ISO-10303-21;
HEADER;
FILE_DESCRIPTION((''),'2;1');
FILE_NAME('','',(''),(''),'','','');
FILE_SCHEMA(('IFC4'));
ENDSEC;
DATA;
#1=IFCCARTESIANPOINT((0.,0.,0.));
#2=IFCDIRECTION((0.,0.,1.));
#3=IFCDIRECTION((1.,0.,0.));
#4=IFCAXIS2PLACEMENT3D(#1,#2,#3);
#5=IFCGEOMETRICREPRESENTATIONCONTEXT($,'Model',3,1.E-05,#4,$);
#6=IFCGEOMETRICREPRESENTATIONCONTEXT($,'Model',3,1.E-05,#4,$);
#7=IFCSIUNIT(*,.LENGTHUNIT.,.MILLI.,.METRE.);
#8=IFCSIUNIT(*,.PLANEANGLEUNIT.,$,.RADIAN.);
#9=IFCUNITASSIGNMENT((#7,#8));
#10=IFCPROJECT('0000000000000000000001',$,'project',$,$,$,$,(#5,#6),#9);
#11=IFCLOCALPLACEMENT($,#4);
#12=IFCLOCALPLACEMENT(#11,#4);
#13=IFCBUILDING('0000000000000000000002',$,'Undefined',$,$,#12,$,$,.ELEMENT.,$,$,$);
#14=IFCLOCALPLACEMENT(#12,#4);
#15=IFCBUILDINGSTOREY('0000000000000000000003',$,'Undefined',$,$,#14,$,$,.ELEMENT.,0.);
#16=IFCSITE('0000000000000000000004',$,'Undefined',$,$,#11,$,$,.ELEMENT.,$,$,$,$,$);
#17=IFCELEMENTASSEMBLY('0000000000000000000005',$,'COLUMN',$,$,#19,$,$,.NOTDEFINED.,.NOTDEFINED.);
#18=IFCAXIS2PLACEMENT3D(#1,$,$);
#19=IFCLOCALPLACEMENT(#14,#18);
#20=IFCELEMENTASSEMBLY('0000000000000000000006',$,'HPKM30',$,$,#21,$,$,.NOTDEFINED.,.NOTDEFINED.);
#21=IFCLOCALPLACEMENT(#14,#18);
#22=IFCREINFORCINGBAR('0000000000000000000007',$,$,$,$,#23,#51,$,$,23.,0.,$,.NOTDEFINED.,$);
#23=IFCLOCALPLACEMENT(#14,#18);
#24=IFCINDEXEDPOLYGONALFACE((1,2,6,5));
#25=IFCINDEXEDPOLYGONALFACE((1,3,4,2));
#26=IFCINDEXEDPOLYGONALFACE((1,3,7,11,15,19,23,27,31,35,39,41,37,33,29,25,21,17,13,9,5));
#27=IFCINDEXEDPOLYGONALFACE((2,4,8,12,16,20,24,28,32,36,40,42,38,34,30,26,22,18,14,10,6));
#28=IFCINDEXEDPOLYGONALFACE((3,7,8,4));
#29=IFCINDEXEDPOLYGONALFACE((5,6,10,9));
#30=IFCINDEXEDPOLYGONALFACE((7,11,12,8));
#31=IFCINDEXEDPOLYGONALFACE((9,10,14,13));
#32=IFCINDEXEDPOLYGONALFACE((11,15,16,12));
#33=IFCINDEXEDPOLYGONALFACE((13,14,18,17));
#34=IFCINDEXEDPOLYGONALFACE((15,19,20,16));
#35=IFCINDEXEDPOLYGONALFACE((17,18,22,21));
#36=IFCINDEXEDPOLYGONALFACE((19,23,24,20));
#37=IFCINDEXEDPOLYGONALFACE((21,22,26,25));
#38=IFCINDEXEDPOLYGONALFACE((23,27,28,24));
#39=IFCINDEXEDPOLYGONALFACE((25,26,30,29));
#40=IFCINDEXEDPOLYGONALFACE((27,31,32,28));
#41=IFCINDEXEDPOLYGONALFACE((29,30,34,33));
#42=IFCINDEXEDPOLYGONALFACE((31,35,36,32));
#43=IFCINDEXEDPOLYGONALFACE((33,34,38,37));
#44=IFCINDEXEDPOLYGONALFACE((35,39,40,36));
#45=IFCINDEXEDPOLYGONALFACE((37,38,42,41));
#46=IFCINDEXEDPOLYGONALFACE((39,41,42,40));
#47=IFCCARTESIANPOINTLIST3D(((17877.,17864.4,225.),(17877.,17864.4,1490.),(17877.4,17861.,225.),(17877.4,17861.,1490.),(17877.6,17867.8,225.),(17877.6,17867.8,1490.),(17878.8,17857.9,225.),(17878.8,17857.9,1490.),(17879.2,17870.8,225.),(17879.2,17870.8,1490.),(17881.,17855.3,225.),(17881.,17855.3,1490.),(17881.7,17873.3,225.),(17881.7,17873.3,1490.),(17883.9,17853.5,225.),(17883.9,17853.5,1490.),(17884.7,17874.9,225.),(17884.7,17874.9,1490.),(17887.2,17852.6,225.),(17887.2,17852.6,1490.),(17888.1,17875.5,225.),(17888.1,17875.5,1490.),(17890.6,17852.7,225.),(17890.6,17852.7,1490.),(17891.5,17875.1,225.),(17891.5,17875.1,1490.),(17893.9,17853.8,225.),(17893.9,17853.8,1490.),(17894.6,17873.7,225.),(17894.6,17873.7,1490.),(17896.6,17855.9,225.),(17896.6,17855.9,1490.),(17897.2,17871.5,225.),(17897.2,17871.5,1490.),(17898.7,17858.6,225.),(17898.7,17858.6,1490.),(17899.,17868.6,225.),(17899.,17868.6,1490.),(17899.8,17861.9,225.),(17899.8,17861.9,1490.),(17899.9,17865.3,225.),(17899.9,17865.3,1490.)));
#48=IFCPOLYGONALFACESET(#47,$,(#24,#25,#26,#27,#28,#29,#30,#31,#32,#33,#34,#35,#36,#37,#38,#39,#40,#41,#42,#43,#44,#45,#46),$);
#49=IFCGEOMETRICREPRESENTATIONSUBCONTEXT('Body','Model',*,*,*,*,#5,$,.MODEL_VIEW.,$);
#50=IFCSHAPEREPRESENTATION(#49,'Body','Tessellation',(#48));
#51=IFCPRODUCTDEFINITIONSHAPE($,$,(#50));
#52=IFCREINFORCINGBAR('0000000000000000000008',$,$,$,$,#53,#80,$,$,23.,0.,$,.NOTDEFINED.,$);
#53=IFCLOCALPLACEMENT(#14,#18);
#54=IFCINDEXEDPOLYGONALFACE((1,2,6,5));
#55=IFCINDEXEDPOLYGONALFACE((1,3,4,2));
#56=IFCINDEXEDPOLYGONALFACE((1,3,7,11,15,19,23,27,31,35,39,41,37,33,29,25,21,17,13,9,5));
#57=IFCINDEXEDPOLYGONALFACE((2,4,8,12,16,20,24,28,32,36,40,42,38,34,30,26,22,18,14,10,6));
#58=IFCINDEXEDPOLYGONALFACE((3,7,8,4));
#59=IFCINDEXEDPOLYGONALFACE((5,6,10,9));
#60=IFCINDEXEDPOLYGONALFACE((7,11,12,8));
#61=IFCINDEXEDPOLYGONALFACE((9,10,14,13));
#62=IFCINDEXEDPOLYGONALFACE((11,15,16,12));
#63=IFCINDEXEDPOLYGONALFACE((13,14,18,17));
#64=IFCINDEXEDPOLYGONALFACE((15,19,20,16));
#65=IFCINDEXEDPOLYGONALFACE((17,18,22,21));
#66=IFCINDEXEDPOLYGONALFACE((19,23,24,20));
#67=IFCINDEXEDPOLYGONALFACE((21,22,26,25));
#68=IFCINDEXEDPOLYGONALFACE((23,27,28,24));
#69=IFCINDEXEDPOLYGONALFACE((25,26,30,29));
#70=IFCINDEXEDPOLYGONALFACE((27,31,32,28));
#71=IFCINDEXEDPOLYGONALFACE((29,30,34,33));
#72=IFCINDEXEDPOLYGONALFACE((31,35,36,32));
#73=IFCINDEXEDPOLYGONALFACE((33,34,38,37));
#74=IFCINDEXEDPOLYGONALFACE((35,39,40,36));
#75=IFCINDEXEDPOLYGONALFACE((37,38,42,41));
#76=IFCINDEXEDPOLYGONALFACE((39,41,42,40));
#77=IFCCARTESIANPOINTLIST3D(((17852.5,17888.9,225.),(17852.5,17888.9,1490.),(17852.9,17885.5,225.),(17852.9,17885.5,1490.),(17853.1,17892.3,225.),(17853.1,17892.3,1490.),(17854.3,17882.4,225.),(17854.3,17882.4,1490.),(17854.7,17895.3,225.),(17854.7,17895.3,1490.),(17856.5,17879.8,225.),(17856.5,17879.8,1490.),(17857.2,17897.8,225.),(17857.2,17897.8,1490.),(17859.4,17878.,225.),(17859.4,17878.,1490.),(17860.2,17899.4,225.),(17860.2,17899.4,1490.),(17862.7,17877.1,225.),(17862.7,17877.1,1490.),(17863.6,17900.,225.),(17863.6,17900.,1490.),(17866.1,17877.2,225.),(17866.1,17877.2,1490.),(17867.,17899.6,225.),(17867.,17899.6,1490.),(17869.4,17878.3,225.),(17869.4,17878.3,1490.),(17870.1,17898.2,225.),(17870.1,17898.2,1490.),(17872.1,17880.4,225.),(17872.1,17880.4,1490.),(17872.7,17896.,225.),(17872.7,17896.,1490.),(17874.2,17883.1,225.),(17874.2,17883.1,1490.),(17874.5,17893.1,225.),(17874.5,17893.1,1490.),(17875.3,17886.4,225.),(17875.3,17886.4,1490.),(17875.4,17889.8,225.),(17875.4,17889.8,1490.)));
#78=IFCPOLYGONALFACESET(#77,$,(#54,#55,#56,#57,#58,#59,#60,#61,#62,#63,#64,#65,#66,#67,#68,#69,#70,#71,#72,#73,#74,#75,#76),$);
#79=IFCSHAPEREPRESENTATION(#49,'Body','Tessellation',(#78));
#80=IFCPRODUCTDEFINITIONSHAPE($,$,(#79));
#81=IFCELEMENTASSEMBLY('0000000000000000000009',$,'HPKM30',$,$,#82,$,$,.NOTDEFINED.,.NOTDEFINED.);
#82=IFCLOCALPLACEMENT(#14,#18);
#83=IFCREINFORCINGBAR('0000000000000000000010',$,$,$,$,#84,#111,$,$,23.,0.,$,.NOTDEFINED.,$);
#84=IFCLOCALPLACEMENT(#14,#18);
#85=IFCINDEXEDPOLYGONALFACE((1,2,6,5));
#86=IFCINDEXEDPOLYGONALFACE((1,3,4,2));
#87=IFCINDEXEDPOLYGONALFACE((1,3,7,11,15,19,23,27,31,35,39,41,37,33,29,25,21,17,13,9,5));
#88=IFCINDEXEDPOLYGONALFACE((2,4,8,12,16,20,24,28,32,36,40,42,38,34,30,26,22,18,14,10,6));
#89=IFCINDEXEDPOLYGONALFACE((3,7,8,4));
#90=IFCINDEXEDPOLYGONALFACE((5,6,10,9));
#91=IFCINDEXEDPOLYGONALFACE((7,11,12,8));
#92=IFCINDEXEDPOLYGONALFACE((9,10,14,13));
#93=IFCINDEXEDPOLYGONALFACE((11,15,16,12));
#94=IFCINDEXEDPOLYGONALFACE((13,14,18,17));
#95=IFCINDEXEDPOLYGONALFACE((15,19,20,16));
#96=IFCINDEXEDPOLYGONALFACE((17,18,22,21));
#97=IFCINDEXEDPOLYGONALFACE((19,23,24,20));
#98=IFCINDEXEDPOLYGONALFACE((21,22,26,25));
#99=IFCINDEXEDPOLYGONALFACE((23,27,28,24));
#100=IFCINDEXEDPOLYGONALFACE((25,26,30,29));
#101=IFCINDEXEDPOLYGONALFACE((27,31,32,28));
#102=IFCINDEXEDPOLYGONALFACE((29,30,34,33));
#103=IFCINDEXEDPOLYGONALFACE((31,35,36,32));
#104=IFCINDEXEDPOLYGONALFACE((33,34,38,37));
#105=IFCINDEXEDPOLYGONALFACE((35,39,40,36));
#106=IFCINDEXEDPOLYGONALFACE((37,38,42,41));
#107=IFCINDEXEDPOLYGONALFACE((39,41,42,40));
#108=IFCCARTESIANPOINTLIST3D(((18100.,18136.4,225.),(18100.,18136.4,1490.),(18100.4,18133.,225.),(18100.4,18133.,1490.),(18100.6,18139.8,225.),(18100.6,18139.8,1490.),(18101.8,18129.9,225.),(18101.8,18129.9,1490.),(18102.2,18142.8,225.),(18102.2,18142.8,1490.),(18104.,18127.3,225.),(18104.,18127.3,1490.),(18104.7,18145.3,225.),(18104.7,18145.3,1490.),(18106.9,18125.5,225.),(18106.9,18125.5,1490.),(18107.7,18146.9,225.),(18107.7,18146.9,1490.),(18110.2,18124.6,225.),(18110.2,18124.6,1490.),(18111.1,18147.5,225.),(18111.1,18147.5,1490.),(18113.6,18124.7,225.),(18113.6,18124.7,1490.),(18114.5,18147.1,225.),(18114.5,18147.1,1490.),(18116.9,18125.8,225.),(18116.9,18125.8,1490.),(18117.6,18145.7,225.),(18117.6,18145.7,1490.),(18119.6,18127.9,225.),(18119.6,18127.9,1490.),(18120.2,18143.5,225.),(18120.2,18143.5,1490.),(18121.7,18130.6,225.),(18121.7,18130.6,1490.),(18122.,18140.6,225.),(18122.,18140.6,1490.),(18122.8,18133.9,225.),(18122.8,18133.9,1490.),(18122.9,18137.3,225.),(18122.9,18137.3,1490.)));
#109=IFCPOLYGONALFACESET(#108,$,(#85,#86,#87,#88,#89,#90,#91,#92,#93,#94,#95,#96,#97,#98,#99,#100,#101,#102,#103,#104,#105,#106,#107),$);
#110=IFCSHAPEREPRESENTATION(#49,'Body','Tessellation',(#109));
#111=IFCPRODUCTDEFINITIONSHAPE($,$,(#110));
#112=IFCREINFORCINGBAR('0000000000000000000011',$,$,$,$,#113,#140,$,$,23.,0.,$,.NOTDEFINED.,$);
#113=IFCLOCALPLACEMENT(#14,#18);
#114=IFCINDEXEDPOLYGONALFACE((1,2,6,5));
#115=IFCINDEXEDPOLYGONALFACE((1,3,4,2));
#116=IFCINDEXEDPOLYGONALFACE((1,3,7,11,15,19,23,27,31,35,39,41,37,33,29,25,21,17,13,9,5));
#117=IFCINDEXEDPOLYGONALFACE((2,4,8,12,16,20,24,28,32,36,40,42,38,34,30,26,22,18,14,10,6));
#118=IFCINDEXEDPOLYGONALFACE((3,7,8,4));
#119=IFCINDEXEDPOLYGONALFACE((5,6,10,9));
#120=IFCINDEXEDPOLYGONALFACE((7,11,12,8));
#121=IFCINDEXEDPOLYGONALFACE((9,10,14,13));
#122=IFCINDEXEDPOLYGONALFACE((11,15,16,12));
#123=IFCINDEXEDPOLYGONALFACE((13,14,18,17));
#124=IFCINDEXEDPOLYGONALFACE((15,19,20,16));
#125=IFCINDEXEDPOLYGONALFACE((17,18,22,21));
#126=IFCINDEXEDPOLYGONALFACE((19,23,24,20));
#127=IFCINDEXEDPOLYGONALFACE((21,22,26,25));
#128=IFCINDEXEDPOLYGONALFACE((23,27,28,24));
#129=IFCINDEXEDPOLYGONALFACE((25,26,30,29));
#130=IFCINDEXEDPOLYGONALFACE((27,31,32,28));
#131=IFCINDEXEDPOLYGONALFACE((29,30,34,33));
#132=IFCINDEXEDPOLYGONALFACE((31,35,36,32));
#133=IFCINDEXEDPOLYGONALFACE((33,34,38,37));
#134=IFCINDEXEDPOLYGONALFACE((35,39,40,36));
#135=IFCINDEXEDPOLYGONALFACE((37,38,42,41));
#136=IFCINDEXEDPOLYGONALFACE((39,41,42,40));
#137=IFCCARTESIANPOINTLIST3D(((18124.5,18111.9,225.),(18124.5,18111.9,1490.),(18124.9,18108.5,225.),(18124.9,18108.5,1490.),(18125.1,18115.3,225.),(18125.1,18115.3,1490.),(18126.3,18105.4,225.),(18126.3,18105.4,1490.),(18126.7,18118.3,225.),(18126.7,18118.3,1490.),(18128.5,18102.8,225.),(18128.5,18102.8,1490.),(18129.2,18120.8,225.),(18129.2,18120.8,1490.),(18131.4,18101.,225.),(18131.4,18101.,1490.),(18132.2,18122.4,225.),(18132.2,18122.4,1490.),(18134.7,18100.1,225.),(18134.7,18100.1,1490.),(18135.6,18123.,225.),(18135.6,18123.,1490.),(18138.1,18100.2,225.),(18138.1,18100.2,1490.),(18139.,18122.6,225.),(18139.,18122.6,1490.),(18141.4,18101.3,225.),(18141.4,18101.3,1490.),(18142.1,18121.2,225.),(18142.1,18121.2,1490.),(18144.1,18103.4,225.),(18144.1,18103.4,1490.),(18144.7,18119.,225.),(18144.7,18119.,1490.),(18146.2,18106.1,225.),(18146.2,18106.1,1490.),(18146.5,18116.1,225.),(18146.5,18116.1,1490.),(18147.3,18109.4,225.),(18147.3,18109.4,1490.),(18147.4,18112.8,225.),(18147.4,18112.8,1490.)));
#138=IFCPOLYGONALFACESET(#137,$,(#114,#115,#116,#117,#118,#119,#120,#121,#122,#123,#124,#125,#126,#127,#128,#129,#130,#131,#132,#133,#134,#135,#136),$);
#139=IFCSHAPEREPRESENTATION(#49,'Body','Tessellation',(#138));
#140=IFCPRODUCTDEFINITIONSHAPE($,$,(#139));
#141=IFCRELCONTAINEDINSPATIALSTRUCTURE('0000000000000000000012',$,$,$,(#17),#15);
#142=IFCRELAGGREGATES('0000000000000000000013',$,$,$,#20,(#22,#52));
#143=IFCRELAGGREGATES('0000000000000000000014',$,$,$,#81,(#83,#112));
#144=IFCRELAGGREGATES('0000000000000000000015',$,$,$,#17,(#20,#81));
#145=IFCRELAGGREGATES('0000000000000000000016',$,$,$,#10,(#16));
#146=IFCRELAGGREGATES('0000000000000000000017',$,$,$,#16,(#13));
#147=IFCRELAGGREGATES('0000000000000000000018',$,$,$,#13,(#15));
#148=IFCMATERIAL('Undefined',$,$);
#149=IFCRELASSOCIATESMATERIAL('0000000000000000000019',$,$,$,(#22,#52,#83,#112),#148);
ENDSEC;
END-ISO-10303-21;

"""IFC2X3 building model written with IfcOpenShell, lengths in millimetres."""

from ifc_helpers import new_model, entity, si_unit, frame, origin_with_axes, place, context, subcontext, project, spatial, source, transform, mapped, material, element, aggregate, save


model = new_model("IFC2X3")

# Units and contexts
model_context_1 = context("Model", 3, precision=1e-05, world=origin_with_axes())
model_context_2 = context("Model", 3, precision=1e-05, world=origin_with_axes())
body_context = subcontext(model_context_1, "Body", "Model", "MODEL_VIEW")
ifc_project = project(units=[si_unit("LENGTHUNIT", "METRE", prefix="MILLI"), si_unit("PLANEANGLEUNIT", "RADIAN")], contexts=[model_context_1, model_context_2])

# Site, building, storey
site_placement = place(None, origin_with_axes())
site = spatial("IfcSite", under=ifc_project, at=site_placement, Name="Undefined", CompositionType="ELEMENT")
building_placement = place(site_placement, origin_with_axes())
building = spatial("IfcBuilding", under=site, at=building_placement, Name="Undefined", CompositionType="ELEMENT")
storey_placement = place(building_placement, origin_with_axes())
storey = spatial("IfcBuildingStorey", under=building, at=storey_placement, Name="Undefined", CompositionType="ELEMENT", Elevation=0.0)

# Element assembly
assembly_1_placement = place(storey_placement, origin_with_axes())
assembly_1 = element("IfcElementAssembly", 1, at=assembly_1_placement, inside=storey, Name="COLUMN", AssemblyPlace="NOTDEFINED", PredefinedType="NOTDEFINED")

# Shared definitions
ifc_material_1 = material(Name="Undefined")

# Element assemblies, reinforcing bars
assembly_2_placement = place(assembly_1_placement, origin_with_axes())
assembly_2 = element("IfcElementAssembly", 2, at=assembly_2_placement, Name="HPKM30", AssemblyPlace="NOTDEFINED", PredefinedType="NOTDEFINED")
shared_shape_1 = source(origin_with_axes(), body_context, "Body", "AdvancedSweptSolid", [
    entity("IfcSweptDiskSolid", entity("IfcTrimmedCurve", entity("IfcLine", entity("IfcCartesianPoint", [0.0, 0.0, 0.0]), entity("IfcVector", entity("IfcDirection", [1.0, 0.0, 0.0]), 1.0)), [entity("IfcParameterValue", 0.0)], [entity("IfcParameterValue", 1265.0)], True, "PARAMETER"), 11.5, None, 0.0, 1265.0),
])
reinforcing_bar_1_placement = place(assembly_2_placement, frame((17888.5, 17864.0, 225.0), z_axis=(0.707107, -0.707107, 0.0), x_axis=(0.0, 0.0, 1.0)))
reinforcing_bar_1 = element("IfcReinforcingBar", 3, at=reinforcing_bar_1_placement, material=ifc_material_1, BarRole="NOTDEFINED", CrossSectionArea=0.0, NominalDiameter=23.0, context=body_context, shape_type="MappedRepresentation", body=[
    mapped(shared_shape_1, transform((0.0, 0.0, 0.0))),
])
shared_shape_2 = source(origin_with_axes(), body_context, "Body", "AdvancedSweptSolid", [
    entity("IfcSweptDiskSolid", entity("IfcTrimmedCurve", entity("IfcLine", entity("IfcCartesianPoint", [0.0, 0.0, 0.0]), entity("IfcVector", entity("IfcDirection", [1.0, 0.0, 0.0]), 1.0)), [entity("IfcParameterValue", 0.0)], [entity("IfcParameterValue", 1265.0)], True, "PARAMETER"), 11.5, None, 0.0, 1265.0),
])
reinforcing_bar_2_placement = place(assembly_2_placement, frame((17864.0, 17888.5, 225.0), z_axis=(0.707107, -0.707107, 0.0), x_axis=(0.0, 0.0, 1.0)))
reinforcing_bar_2 = element("IfcReinforcingBar", 4, at=reinforcing_bar_2_placement, material=ifc_material_1, BarRole="NOTDEFINED", CrossSectionArea=0.0, NominalDiameter=23.0, context=body_context, shape_type="MappedRepresentation", body=[
    mapped(shared_shape_2, transform((0.0, 0.0, 0.0))),
])
aggregate(assembly_2, [reinforcing_bar_1, reinforcing_bar_2])
assembly_3_placement = place(assembly_1_placement, origin_with_axes())
assembly_3 = element("IfcElementAssembly", 5, at=assembly_3_placement, Name="HPKM30", AssemblyPlace="NOTDEFINED", PredefinedType="NOTDEFINED")
shared_shape_3 = source(origin_with_axes(), body_context, "Body", "AdvancedSweptSolid", [
    entity("IfcSweptDiskSolid", entity("IfcTrimmedCurve", entity("IfcLine", entity("IfcCartesianPoint", [0.0, 0.0, 0.0]), entity("IfcVector", entity("IfcDirection", [1.0, 0.0, 0.0]), 1.0)), [entity("IfcParameterValue", 0.0)], [entity("IfcParameterValue", 1265.0)], True, "PARAMETER"), 11.5, None, 0.0, 1265.0),
])
reinforcing_bar_3_placement = place(assembly_3_placement, frame((18111.5, 18136.0, 225.0), z_axis=(0.707107, -0.707107, 0.0), x_axis=(0.0, 0.0, 1.0)))
reinforcing_bar_3 = element("IfcReinforcingBar", 6, at=reinforcing_bar_3_placement, material=ifc_material_1, BarRole="NOTDEFINED", CrossSectionArea=0.0, NominalDiameter=23.0, context=body_context, shape_type="MappedRepresentation", body=[
    mapped(shared_shape_3, transform((0.0, 0.0, 0.0))),
])
shared_shape_4 = source(origin_with_axes(), body_context, "Body", "AdvancedSweptSolid", [
    entity("IfcSweptDiskSolid", entity("IfcTrimmedCurve", entity("IfcLine", entity("IfcCartesianPoint", [0.0, 0.0, 0.0]), entity("IfcVector", entity("IfcDirection", [1.0, 0.0, 0.0]), 1.0)), [entity("IfcParameterValue", 0.0)], [entity("IfcParameterValue", 1265.0)], True, "PARAMETER"), 11.5, None, 0.0, 1265.0),
])
reinforcing_bar_4_placement = place(assembly_3_placement, frame((18136.0, 18111.5, 225.0), z_axis=(0.707107, -0.707107, 0.0), x_axis=(0.0, 0.0, 1.0)))
reinforcing_bar_4 = element("IfcReinforcingBar", 7, at=reinforcing_bar_4_placement, material=ifc_material_1, BarRole="NOTDEFINED", CrossSectionArea=0.0, NominalDiameter=23.0, context=body_context, shape_type="MappedRepresentation", body=[
    mapped(shared_shape_4, transform((0.0, 0.0, 0.0))),
])
aggregate(assembly_3, [reinforcing_bar_3, reinforcing_bar_4])

aggregate(assembly_1, [assembly_2, assembly_3])

save(model, "model.ifc")
